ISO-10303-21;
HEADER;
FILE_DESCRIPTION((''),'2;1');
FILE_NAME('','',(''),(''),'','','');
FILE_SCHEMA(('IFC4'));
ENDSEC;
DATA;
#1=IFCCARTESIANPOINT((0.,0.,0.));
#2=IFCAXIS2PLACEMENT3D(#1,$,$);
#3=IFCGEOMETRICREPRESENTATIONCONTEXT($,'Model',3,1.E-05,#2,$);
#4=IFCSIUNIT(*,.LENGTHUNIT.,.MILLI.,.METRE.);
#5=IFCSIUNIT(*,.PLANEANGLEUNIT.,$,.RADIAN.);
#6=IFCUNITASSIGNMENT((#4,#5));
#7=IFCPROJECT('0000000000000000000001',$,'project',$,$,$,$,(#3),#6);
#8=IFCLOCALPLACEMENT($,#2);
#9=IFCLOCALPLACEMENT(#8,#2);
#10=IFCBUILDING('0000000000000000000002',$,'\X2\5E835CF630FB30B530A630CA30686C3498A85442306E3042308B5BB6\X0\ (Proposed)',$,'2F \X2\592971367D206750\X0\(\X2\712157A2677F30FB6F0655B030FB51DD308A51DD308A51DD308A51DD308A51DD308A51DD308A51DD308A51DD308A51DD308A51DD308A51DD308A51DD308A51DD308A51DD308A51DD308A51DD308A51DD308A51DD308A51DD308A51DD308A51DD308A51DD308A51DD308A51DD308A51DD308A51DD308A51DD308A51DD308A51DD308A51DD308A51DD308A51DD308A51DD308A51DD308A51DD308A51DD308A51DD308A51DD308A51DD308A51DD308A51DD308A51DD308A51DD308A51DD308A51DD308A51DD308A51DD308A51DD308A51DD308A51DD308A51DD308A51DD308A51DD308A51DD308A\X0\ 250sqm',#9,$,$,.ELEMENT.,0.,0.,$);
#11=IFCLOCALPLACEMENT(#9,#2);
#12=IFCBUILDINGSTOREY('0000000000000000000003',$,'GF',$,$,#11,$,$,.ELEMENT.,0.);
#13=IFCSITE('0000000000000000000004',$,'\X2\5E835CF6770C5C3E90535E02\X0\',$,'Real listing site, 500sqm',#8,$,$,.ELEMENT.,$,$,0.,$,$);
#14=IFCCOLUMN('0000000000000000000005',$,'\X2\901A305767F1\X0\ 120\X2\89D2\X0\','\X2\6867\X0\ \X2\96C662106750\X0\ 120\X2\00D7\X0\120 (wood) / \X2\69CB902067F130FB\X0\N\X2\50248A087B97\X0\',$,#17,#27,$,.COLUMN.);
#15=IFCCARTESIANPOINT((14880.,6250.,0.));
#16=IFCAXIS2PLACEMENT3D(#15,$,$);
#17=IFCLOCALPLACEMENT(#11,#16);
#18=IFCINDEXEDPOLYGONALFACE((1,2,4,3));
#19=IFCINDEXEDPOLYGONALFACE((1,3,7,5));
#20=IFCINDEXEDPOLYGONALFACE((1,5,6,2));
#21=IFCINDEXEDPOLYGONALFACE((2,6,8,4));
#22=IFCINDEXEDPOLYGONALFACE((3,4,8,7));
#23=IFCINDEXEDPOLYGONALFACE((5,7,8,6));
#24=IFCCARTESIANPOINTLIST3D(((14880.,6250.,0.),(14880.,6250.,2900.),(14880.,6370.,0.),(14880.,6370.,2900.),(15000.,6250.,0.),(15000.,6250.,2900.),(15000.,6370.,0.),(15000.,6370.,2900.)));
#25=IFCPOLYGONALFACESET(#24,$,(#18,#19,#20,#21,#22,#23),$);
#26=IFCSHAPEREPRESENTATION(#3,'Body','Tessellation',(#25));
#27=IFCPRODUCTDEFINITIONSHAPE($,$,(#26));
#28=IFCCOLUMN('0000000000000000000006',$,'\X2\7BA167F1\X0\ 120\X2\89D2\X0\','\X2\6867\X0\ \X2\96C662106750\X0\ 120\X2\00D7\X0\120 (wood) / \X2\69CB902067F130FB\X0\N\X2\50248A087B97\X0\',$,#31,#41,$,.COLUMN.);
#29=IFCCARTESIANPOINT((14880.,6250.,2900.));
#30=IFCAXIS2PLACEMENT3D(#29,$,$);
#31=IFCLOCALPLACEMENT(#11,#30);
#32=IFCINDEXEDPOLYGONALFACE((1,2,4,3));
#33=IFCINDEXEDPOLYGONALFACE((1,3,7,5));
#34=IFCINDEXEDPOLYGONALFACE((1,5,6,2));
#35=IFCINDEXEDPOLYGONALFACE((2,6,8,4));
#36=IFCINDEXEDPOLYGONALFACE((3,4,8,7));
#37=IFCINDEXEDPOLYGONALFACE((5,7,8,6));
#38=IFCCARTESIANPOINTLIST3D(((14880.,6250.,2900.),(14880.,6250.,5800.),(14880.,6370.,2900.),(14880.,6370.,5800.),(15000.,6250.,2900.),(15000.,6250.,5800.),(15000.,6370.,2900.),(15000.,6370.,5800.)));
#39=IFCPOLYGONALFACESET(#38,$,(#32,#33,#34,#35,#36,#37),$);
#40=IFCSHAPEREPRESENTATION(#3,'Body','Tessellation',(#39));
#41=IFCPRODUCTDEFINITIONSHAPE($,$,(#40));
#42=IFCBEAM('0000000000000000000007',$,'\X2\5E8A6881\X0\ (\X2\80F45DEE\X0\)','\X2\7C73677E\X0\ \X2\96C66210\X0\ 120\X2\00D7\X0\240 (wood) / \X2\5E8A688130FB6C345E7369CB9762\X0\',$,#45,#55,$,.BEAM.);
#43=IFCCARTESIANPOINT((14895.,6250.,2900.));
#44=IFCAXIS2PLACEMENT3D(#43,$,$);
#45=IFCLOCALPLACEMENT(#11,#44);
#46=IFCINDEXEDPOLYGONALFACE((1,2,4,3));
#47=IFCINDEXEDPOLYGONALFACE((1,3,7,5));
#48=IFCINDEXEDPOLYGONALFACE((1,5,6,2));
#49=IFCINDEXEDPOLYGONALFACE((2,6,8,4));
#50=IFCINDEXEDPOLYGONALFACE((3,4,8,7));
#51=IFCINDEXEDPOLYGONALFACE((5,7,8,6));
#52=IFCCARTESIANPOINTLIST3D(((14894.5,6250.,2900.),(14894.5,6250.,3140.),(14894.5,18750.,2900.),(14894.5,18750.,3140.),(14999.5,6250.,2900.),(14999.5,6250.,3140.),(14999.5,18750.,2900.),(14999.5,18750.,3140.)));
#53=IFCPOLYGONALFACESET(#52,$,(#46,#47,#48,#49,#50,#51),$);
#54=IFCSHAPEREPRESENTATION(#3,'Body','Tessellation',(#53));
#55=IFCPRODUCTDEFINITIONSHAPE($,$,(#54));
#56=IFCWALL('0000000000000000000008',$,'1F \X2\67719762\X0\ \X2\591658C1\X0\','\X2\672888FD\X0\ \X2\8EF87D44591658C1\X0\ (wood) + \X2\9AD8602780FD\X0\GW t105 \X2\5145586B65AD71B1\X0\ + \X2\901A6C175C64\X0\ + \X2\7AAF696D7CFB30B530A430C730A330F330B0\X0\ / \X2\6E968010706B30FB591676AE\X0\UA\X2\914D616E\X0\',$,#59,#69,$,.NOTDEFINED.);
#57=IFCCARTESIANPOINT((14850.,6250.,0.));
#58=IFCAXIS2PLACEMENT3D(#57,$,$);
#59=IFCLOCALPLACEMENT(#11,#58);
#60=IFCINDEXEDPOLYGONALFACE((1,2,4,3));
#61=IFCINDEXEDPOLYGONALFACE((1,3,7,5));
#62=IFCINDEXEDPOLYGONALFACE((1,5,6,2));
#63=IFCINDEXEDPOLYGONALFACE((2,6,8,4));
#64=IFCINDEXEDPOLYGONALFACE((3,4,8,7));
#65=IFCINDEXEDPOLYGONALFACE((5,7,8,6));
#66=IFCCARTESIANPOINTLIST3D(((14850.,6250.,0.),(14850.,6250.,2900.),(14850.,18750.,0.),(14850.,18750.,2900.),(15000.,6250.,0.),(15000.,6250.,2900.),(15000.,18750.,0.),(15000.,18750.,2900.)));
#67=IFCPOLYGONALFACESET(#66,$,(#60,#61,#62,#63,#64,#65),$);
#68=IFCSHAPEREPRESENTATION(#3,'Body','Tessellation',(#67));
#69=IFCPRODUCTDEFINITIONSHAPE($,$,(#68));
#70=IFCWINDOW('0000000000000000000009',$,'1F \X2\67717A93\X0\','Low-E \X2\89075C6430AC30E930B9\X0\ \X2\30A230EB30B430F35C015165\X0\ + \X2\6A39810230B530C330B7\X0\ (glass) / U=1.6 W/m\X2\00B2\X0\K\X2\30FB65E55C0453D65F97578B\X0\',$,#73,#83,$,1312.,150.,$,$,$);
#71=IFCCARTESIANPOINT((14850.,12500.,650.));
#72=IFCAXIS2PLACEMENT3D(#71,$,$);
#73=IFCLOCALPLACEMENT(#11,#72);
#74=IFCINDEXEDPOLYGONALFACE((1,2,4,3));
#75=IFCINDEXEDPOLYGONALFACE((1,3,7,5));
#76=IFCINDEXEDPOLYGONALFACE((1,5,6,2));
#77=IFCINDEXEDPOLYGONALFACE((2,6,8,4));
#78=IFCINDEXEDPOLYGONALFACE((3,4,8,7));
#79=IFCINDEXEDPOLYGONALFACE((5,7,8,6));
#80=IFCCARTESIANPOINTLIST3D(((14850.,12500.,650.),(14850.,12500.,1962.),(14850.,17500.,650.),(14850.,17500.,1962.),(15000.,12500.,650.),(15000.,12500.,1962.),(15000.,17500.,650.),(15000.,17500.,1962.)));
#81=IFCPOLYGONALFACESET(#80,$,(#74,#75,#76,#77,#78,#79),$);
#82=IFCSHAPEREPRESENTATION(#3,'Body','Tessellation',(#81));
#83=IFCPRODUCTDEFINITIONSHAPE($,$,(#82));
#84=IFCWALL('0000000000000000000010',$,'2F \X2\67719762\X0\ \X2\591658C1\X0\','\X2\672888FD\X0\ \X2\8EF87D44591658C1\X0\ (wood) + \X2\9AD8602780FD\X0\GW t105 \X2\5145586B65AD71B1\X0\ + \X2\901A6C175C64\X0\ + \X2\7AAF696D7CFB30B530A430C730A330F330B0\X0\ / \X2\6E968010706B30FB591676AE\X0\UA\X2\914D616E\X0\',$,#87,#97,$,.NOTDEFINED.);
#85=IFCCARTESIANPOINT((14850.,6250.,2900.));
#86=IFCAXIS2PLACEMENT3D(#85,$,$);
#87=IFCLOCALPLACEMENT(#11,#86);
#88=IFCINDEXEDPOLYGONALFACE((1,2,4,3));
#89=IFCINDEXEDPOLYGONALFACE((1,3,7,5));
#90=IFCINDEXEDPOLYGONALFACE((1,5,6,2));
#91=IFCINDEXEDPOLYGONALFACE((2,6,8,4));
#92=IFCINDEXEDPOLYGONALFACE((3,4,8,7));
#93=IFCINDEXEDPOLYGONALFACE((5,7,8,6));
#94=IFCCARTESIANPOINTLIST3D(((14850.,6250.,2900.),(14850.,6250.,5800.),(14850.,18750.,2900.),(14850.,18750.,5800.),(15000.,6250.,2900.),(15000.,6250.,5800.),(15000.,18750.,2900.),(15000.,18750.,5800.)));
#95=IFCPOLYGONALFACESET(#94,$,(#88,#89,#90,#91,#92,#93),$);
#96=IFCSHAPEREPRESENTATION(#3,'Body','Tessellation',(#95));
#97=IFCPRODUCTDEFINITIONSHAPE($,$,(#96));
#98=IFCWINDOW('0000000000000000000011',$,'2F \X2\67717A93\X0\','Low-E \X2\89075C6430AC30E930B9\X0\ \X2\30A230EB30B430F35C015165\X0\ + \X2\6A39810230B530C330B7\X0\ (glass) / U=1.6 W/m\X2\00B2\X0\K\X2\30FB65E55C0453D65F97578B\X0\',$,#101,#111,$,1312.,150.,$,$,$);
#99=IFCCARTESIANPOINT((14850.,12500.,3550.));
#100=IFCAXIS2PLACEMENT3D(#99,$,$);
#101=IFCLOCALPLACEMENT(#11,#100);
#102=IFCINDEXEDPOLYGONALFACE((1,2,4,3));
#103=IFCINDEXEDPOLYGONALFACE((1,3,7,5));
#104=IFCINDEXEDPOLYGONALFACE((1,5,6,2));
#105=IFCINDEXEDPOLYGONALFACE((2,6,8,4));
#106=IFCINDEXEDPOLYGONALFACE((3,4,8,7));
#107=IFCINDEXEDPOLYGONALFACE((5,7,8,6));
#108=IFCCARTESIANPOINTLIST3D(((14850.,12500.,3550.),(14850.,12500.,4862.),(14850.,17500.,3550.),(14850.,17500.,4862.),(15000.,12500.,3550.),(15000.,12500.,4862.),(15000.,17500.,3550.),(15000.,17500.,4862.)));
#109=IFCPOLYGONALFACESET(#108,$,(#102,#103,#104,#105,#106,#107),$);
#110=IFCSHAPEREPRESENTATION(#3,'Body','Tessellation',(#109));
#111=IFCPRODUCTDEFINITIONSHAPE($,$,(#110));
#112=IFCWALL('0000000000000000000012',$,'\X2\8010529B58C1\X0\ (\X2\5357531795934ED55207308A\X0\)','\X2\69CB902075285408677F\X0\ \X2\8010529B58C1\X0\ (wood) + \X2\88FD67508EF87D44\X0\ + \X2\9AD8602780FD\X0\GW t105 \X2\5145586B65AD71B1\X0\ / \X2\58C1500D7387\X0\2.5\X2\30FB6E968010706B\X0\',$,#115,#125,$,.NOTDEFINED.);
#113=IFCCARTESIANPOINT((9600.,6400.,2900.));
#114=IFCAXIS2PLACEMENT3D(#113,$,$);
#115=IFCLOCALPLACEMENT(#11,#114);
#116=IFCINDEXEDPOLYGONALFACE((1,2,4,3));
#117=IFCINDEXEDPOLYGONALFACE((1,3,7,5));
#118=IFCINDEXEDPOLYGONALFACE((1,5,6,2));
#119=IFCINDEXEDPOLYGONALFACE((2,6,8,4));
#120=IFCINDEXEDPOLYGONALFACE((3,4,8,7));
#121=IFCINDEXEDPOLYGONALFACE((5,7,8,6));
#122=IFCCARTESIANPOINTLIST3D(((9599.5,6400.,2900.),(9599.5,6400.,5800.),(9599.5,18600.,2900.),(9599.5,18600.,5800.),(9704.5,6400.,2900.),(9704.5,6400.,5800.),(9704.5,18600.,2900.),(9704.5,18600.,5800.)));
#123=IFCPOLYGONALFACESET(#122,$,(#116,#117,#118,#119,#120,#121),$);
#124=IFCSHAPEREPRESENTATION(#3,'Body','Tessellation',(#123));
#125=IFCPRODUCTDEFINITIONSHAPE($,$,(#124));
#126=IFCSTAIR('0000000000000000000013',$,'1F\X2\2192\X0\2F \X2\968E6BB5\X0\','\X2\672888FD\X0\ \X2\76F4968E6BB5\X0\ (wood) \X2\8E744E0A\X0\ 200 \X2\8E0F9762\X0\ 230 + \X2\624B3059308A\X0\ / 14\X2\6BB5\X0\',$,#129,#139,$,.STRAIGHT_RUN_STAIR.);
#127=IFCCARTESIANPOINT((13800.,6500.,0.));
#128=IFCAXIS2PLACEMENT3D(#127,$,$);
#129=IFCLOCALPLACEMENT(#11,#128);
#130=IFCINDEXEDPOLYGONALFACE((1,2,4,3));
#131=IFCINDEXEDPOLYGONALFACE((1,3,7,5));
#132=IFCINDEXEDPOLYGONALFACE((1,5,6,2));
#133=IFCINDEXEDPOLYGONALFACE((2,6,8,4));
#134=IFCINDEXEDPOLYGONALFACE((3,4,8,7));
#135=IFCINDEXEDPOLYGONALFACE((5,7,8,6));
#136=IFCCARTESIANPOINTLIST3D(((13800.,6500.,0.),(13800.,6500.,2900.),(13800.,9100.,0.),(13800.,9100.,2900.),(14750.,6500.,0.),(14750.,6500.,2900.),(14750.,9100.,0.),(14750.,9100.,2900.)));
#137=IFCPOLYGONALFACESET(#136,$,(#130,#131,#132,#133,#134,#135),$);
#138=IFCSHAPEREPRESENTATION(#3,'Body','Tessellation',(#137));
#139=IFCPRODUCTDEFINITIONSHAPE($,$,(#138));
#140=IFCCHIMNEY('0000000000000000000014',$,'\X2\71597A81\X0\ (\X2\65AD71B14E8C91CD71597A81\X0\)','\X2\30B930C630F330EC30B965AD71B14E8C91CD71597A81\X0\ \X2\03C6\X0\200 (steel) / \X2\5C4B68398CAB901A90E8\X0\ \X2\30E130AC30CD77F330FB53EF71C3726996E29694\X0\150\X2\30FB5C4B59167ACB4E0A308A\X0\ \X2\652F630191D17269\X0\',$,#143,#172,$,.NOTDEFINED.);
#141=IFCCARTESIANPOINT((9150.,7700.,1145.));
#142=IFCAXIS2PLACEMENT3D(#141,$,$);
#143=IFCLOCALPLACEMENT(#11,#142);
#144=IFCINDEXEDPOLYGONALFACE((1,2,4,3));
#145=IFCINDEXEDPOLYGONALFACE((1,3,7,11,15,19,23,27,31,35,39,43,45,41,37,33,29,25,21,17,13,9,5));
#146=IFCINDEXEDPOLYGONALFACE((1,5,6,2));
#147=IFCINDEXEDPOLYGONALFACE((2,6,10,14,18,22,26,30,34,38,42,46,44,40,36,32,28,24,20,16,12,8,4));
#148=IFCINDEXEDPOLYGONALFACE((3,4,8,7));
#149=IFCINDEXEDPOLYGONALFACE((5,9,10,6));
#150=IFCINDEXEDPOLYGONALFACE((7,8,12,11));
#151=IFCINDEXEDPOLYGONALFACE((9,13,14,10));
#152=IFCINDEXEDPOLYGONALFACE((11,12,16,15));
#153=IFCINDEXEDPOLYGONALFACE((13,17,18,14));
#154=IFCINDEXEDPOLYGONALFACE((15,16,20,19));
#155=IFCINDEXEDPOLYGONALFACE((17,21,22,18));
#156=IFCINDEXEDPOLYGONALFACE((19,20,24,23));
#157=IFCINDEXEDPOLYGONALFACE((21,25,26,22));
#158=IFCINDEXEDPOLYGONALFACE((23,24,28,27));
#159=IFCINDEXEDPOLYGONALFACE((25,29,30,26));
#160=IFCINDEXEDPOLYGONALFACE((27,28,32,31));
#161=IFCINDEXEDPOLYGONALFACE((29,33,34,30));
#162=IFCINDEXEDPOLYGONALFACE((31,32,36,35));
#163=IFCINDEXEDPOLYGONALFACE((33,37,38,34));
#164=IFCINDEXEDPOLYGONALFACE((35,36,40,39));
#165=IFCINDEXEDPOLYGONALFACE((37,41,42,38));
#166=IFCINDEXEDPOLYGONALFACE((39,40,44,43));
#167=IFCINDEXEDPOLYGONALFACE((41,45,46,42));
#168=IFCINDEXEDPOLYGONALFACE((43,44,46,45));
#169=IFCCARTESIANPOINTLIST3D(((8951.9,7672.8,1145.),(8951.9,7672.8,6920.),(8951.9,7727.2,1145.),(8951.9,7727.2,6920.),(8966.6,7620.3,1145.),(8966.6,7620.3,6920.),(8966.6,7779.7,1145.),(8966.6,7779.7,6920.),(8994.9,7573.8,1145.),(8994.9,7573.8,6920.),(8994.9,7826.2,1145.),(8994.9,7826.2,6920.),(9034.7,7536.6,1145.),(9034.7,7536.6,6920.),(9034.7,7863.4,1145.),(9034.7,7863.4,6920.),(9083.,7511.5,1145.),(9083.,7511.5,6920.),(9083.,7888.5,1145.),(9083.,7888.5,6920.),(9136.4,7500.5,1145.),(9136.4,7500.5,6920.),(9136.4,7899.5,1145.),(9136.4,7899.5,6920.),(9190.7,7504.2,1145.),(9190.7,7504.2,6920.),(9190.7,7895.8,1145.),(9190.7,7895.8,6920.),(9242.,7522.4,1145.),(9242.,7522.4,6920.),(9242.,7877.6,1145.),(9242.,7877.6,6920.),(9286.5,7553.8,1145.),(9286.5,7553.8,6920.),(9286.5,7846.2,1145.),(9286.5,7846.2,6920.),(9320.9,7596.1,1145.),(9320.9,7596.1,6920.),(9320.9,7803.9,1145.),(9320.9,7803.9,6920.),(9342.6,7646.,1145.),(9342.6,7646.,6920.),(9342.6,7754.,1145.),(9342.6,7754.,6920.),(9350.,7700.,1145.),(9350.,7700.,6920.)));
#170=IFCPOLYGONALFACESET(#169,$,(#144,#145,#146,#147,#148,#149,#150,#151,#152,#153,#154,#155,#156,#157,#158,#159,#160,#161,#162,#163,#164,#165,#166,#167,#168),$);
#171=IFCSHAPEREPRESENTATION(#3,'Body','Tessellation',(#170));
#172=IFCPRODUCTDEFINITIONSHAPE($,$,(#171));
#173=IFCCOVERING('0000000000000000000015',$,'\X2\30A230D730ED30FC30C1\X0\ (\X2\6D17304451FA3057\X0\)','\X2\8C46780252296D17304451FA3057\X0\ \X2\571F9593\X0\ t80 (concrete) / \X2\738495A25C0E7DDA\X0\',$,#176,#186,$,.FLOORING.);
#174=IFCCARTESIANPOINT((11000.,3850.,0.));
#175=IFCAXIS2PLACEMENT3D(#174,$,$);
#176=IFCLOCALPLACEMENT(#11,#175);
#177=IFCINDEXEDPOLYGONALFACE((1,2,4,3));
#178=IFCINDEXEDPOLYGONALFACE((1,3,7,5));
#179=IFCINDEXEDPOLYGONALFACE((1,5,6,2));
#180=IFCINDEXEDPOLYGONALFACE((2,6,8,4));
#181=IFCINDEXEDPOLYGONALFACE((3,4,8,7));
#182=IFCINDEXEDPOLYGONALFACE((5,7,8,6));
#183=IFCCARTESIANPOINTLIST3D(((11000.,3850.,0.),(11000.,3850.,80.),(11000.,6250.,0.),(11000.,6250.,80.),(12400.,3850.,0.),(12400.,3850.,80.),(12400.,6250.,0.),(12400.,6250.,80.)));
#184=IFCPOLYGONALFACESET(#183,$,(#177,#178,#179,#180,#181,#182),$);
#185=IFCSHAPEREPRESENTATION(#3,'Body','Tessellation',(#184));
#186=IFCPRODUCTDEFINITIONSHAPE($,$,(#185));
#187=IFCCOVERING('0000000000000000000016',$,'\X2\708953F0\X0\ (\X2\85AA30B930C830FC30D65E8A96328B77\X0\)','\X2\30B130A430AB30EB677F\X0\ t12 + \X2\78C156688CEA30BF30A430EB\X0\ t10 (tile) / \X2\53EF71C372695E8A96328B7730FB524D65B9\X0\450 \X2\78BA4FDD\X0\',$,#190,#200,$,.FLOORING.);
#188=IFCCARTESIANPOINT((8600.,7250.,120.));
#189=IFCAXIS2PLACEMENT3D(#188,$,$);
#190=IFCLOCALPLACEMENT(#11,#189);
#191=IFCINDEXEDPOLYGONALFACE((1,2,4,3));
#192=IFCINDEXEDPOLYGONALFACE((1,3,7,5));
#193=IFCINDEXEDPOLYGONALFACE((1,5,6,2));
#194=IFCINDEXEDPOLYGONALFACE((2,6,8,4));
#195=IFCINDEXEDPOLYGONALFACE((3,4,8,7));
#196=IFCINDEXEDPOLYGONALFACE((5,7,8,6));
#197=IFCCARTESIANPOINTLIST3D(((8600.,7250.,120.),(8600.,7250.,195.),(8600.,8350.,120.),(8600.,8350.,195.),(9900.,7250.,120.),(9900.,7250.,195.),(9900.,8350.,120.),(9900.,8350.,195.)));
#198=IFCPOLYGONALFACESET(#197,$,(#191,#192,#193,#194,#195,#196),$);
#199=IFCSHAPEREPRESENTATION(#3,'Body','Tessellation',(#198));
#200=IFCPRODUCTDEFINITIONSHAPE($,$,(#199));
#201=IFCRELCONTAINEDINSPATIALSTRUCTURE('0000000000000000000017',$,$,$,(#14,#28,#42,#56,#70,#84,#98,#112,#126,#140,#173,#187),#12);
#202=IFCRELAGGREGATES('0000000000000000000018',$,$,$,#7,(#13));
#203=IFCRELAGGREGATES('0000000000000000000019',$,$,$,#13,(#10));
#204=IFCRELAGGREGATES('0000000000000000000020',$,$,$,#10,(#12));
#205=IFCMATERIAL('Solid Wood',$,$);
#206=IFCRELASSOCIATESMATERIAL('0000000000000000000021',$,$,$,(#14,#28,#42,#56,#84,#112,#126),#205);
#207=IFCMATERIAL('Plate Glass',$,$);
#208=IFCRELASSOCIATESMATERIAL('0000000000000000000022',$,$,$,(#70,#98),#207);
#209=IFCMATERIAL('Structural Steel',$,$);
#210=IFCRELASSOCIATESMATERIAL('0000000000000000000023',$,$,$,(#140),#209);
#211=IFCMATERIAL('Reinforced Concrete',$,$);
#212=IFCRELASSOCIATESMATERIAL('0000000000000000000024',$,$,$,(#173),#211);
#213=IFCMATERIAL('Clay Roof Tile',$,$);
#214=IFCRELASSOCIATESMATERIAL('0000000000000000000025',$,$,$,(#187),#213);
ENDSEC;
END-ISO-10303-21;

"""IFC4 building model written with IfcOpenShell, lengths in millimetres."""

from ifc_helpers import new_model, si_unit, frame, frame_2d, origin, origin_2d, place, context, project, spatial, rectangle, circle, extrude, material, element, fill, save


model = new_model("IFC4")

# Units and contexts
model_context = context("Model", 3, precision=1e-05, world=origin())
ifc_project = project(units=[si_unit("LENGTHUNIT", "METRE", prefix="MILLI"), si_unit("PLANEANGLEUNIT", "RADIAN")], contexts=[model_context])

# Site, building, storey
site_placement = place(None, origin())
site = spatial("IfcSite", under=ifc_project, at=site_placement, Name="広島県尾道市", ObjectType="Real listing site, 500sqm", CompositionType="ELEMENT", RefElevation=0.0)
building_placement = place(site_placement, origin())
building = spatial("IfcBuilding", under=site, at=building_placement, Name="広島・サウナと水風呂のある家 (Proposed)", ObjectType="2F 天然素材(無垢板・漆喰・凝り凝り凝り凝り凝り凝り凝り凝り凝り凝り凝り凝り凝り凝り凝り凝り凝り凝り凝り凝り凝り凝り凝り凝り凝り凝り凝り凝り凝り凝り凝り凝り凝り凝り凝り凝り凝り凝り凝り凝り凝り凝り凝り凝り凝り凝り凝り凝り凝り凝り凝り凝り凝り凝り 250sqm", CompositionType="ELEMENT", ElevationOfRefHeight=0.0, ElevationOfTerrain=0.0)
storey_placement = place(building_placement, origin())
storey = spatial("IfcBuildingStorey", under=building, at=storey_placement, Name="GF", CompositionType="ELEMENT", Elevation=0.0)

# Columns
ifc_material_1 = material(Name="Solid Wood")
column_1_placement = place(storey_placement, frame((14880.0, 6250.0, 0.0)))
element("IfcColumn", 1, at=column_1_placement, inside=storey, material=ifc_material_1, Name="通し柱 120角", Description="桧 集成材 120×120 (wood) / 構造柱・N値計算", PredefinedType="COLUMN", context=model_context, shape_type="SweptSolid", body=[
    extrude(rectangle(XDim=120.0, YDim=120.0, at=frame_2d((60.0, 60.0))), frame((14880.0, 6250.0, 0.0)), (0.0, 0.0, 1.0), 2900.0),
])
column_2_placement = place(storey_placement, frame((14880.0, 6250.0, 2900.0)))
element("IfcColumn", 2, at=column_2_placement, inside=storey, material=ifc_material_1, Name="管柱 120角", Description="桧 集成材 120×120 (wood) / 構造柱・N値計算", PredefinedType="COLUMN", context=model_context, shape_type="SweptSolid", body=[
    extrude(rectangle(XDim=120.0, YDim=120.0, at=frame_2d((60.0, 60.0))), frame((14880.0, 6250.0, 2900.0)), (0.0, 0.0, 1.0), 2900.0),
])

# Beam
beam_1_placement = place(storey_placement, frame((14895.0, 6250.0, 2900.0)))
element("IfcBeam", 3, at=beam_1_placement, inside=storey, material=ifc_material_1, Name="床梁 (胴差)", Description="米松 集成 120×240 (wood) / 床梁・水平構面", PredefinedType="BEAM", context=model_context, shape_type="SweptSolid", body=[
    extrude(rectangle(XDim=105.0, YDim=12500.0, at=frame_2d((52.0, 6250.0))), frame((14895.0, 6250.0, 2900.0)), (0.0, 0.0, 1.0), 240.0),
])

# Wall, opening, window
wall_1_placement = place(storey_placement, frame((14850.0, 6250.0, 0.0)))
wall_1 = element("IfcWall", 4, at=wall_1_placement, inside=storey, material=ifc_material_1, Name="1F 東面 外壁", Description="木製 軸組外壁 (wood) + 高性能GW t105 充填断熱 + 通気層 + 窯業系サイディング / 準耐火・外皮UA配慮", PredefinedType="NOTDEFINED", context=model_context, shape_type="SweptSolid", body=[
    extrude(rectangle(XDim=150.0, YDim=12500.0, at=frame_2d((75.0, 6250.0))), frame((14850.0, 6250.0, 0.0)), (0.0, 0.0, 1.0), 2900.0),
])
opening_1_placement = place(storey_placement, frame((14850.0, 12500.0, 650.0)))
opening_1 = element("IfcOpeningElement", 5, at=opening_1_placement, cuts=wall_1, PredefinedType="NOTDEFINED", context=model_context, shape_type="SweptSolid", body=[
    extrude(rectangle(XDim=150.0, YDim=5000.0, at=frame_2d((75.0, 2500.0))), frame((14850.0, 12500.0, 650.0)), (0.0, 0.0, 1.0), 1312.0),
])
ifc_material_2 = material(Name="Plate Glass")
window_1_placement = place(storey_placement, frame((14850.0, 12500.0, 650.0)))
window_1 = element("IfcWindow", 6, at=window_1_placement, inside=storey, material=ifc_material_2, Name="1F 東窓", Description="Low-E 複層ガラス アルゴン封入 + 樹脂サッシ (glass) / U=1.6 W/m²K・日射取得型", OverallHeight=1312.0, OverallWidth=150.0, context=model_context, shape_type="SweptSolid", body=[
    extrude(rectangle(XDim=150.0, YDim=5000.0, at=frame_2d((75.0, 2500.0))), frame((14850.0, 12500.0, 650.0)), (0.0, 0.0, 1.0), 1312.0),
])
fill(opening_1, window_1)

# Wall, opening, window
wall_2_placement = place(storey_placement, frame((14850.0, 6250.0, 2900.0)))
wall_2 = element("IfcWall", 7, at=wall_2_placement, inside=storey, material=ifc_material_1, Name="2F 東面 外壁", Description="木製 軸組外壁 (wood) + 高性能GW t105 充填断熱 + 通気層 + 窯業系サイディング / 準耐火・外皮UA配慮", PredefinedType="NOTDEFINED", context=model_context, shape_type="SweptSolid", body=[
    extrude(rectangle(XDim=150.0, YDim=12500.0, at=frame_2d((75.0, 6250.0))), frame((14850.0, 6250.0, 2900.0)), (0.0, 0.0, 1.0), 2900.0),
])
opening_2_placement = place(storey_placement, frame((14850.0, 12500.0, 3550.0)))
opening_2 = element("IfcOpeningElement", 8, at=opening_2_placement, cuts=wall_2, PredefinedType="NOTDEFINED", context=model_context, shape_type="SweptSolid", body=[
    extrude(rectangle(XDim=150.0, YDim=5000.0, at=frame_2d((75.0, 2500.0))), frame((14850.0, 12500.0, 3550.0)), (0.0, 0.0, 1.0), 1312.0),
])
window_2_placement = place(storey_placement, frame((14850.0, 12500.0, 3550.0)))
window_2 = element("IfcWindow", 9, at=window_2_placement, inside=storey, material=ifc_material_2, Name="2F 東窓", Description="Low-E 複層ガラス アルゴン封入 + 樹脂サッシ (glass) / U=1.6 W/m²K・日射取得型", OverallHeight=1312.0, OverallWidth=150.0, context=model_context, shape_type="SweptSolid", body=[
    extrude(rectangle(XDim=150.0, YDim=5000.0, at=frame_2d((75.0, 2500.0))), frame((14850.0, 12500.0, 3550.0)), (0.0, 0.0, 1.0), 1312.0),
])
fill(opening_2, window_2)

# Wall
wall_3_placement = place(storey_placement, frame((9600.0, 6400.0, 2900.0)))
element("IfcWall", 10, at=wall_3_placement, inside=storey, material=ifc_material_1, Name="耐力壁 (南北間仕切り)", Description="構造用合板 耐力壁 (wood) + 製材軸組 + 高性能GW t105 充填断熱 / 壁倍率2.5・準耐火", PredefinedType="NOTDEFINED", context=model_context, shape_type="SweptSolid", body=[
    extrude(rectangle(XDim=105.0, YDim=12200.0, at=frame_2d((52.0, 6100.0))), frame((9600.0, 6400.0, 2900.0)), (0.0, 0.0, 1.0), 2900.0),
])

# Stair
stair_placement = place(storey_placement, frame((13800.0, 6500.0, 0.0)))
element("IfcStair", 11, at=stair_placement, inside=storey, material=ifc_material_1, Name="1F→2F 階段", Description="木製 直階段 (wood) 蹴上 200 踏面 230 + 手すり / 14段", PredefinedType="STRAIGHT_RUN_STAIR", context=model_context, shape_type="SweptSolid", body=[
    extrude(rectangle(XDim=950.0, YDim=2600.0, at=frame_2d((475.0, 1300.0))), frame((13800.0, 6500.0, 0.0)), (0.0, 0.0, 1.0), 2900.0),
])

# Chimney
ifc_material_3 = material(Name="Structural Steel")
chimney_placement = place(storey_placement, frame((9150.0, 7700.0, 1145.0)))
element("IfcChimney", 12, at=chimney_placement, inside=storey, material=ifc_material_3, Name="煙突 (断熱二重煙突)", Description="ステンレス断熱二重煙突 φ200 (steel) / 屋根貫通部 メガネ石・可燃物離隔150・屋外立上り 支持金物", PredefinedType="NOTDEFINED", context=model_context, shape_type="SweptSolid", body=[
    extrude(circle(Radius=200.0, at=origin_2d()), frame((9150.0, 7700.0, 1145.0)), (0.0, 0.0, 1.0), 5775.0),
])

# Coverings
ifc_material_4 = material(Name="Reinforced Concrete")
covering_1_placement = place(storey_placement, frame((11000.0, 3850.0, 0.0)))
element("IfcCovering", 13, at=covering_1_placement, inside=storey, material=ifc_material_4, Name="アプローチ (洗い出し)", Description="豆砂利洗い出し 土間 t80 (concrete) / 玄関導線", PredefinedType="FLOORING", context=model_context, shape_type="SweptSolid", body=[
    extrude(rectangle(XDim=1400.0, YDim=2400.0, at=frame_2d((700.0, 1200.0))), frame((11000.0, 3850.0, 0.0)), (0.0, 0.0, 1.0), 80.0),
])
ifc_material_5 = material(Name="Clay Roof Tile")
covering_2_placement = place(storey_placement, frame((8600.0, 7250.0, 120.0)))
element("IfcCovering", 14, at=covering_2_placement, inside=storey, material=ifc_material_5, Name="炉台 (薪ストーブ床防護)", Description="ケイカル板 t12 + 磁器質タイル t10 (tile) / 可燃物床防護・前方450 確保", PredefinedType="FLOORING", context=model_context, shape_type="SweptSolid", body=[
    extrude(rectangle(XDim=1300.0, YDim=1100.0, at=frame_2d((650.0, 550.0))), frame((8600.0, 7250.0, 120.0)), (0.0, 0.0, 1.0), 75.0),
])

save(model, "model.ifc")
